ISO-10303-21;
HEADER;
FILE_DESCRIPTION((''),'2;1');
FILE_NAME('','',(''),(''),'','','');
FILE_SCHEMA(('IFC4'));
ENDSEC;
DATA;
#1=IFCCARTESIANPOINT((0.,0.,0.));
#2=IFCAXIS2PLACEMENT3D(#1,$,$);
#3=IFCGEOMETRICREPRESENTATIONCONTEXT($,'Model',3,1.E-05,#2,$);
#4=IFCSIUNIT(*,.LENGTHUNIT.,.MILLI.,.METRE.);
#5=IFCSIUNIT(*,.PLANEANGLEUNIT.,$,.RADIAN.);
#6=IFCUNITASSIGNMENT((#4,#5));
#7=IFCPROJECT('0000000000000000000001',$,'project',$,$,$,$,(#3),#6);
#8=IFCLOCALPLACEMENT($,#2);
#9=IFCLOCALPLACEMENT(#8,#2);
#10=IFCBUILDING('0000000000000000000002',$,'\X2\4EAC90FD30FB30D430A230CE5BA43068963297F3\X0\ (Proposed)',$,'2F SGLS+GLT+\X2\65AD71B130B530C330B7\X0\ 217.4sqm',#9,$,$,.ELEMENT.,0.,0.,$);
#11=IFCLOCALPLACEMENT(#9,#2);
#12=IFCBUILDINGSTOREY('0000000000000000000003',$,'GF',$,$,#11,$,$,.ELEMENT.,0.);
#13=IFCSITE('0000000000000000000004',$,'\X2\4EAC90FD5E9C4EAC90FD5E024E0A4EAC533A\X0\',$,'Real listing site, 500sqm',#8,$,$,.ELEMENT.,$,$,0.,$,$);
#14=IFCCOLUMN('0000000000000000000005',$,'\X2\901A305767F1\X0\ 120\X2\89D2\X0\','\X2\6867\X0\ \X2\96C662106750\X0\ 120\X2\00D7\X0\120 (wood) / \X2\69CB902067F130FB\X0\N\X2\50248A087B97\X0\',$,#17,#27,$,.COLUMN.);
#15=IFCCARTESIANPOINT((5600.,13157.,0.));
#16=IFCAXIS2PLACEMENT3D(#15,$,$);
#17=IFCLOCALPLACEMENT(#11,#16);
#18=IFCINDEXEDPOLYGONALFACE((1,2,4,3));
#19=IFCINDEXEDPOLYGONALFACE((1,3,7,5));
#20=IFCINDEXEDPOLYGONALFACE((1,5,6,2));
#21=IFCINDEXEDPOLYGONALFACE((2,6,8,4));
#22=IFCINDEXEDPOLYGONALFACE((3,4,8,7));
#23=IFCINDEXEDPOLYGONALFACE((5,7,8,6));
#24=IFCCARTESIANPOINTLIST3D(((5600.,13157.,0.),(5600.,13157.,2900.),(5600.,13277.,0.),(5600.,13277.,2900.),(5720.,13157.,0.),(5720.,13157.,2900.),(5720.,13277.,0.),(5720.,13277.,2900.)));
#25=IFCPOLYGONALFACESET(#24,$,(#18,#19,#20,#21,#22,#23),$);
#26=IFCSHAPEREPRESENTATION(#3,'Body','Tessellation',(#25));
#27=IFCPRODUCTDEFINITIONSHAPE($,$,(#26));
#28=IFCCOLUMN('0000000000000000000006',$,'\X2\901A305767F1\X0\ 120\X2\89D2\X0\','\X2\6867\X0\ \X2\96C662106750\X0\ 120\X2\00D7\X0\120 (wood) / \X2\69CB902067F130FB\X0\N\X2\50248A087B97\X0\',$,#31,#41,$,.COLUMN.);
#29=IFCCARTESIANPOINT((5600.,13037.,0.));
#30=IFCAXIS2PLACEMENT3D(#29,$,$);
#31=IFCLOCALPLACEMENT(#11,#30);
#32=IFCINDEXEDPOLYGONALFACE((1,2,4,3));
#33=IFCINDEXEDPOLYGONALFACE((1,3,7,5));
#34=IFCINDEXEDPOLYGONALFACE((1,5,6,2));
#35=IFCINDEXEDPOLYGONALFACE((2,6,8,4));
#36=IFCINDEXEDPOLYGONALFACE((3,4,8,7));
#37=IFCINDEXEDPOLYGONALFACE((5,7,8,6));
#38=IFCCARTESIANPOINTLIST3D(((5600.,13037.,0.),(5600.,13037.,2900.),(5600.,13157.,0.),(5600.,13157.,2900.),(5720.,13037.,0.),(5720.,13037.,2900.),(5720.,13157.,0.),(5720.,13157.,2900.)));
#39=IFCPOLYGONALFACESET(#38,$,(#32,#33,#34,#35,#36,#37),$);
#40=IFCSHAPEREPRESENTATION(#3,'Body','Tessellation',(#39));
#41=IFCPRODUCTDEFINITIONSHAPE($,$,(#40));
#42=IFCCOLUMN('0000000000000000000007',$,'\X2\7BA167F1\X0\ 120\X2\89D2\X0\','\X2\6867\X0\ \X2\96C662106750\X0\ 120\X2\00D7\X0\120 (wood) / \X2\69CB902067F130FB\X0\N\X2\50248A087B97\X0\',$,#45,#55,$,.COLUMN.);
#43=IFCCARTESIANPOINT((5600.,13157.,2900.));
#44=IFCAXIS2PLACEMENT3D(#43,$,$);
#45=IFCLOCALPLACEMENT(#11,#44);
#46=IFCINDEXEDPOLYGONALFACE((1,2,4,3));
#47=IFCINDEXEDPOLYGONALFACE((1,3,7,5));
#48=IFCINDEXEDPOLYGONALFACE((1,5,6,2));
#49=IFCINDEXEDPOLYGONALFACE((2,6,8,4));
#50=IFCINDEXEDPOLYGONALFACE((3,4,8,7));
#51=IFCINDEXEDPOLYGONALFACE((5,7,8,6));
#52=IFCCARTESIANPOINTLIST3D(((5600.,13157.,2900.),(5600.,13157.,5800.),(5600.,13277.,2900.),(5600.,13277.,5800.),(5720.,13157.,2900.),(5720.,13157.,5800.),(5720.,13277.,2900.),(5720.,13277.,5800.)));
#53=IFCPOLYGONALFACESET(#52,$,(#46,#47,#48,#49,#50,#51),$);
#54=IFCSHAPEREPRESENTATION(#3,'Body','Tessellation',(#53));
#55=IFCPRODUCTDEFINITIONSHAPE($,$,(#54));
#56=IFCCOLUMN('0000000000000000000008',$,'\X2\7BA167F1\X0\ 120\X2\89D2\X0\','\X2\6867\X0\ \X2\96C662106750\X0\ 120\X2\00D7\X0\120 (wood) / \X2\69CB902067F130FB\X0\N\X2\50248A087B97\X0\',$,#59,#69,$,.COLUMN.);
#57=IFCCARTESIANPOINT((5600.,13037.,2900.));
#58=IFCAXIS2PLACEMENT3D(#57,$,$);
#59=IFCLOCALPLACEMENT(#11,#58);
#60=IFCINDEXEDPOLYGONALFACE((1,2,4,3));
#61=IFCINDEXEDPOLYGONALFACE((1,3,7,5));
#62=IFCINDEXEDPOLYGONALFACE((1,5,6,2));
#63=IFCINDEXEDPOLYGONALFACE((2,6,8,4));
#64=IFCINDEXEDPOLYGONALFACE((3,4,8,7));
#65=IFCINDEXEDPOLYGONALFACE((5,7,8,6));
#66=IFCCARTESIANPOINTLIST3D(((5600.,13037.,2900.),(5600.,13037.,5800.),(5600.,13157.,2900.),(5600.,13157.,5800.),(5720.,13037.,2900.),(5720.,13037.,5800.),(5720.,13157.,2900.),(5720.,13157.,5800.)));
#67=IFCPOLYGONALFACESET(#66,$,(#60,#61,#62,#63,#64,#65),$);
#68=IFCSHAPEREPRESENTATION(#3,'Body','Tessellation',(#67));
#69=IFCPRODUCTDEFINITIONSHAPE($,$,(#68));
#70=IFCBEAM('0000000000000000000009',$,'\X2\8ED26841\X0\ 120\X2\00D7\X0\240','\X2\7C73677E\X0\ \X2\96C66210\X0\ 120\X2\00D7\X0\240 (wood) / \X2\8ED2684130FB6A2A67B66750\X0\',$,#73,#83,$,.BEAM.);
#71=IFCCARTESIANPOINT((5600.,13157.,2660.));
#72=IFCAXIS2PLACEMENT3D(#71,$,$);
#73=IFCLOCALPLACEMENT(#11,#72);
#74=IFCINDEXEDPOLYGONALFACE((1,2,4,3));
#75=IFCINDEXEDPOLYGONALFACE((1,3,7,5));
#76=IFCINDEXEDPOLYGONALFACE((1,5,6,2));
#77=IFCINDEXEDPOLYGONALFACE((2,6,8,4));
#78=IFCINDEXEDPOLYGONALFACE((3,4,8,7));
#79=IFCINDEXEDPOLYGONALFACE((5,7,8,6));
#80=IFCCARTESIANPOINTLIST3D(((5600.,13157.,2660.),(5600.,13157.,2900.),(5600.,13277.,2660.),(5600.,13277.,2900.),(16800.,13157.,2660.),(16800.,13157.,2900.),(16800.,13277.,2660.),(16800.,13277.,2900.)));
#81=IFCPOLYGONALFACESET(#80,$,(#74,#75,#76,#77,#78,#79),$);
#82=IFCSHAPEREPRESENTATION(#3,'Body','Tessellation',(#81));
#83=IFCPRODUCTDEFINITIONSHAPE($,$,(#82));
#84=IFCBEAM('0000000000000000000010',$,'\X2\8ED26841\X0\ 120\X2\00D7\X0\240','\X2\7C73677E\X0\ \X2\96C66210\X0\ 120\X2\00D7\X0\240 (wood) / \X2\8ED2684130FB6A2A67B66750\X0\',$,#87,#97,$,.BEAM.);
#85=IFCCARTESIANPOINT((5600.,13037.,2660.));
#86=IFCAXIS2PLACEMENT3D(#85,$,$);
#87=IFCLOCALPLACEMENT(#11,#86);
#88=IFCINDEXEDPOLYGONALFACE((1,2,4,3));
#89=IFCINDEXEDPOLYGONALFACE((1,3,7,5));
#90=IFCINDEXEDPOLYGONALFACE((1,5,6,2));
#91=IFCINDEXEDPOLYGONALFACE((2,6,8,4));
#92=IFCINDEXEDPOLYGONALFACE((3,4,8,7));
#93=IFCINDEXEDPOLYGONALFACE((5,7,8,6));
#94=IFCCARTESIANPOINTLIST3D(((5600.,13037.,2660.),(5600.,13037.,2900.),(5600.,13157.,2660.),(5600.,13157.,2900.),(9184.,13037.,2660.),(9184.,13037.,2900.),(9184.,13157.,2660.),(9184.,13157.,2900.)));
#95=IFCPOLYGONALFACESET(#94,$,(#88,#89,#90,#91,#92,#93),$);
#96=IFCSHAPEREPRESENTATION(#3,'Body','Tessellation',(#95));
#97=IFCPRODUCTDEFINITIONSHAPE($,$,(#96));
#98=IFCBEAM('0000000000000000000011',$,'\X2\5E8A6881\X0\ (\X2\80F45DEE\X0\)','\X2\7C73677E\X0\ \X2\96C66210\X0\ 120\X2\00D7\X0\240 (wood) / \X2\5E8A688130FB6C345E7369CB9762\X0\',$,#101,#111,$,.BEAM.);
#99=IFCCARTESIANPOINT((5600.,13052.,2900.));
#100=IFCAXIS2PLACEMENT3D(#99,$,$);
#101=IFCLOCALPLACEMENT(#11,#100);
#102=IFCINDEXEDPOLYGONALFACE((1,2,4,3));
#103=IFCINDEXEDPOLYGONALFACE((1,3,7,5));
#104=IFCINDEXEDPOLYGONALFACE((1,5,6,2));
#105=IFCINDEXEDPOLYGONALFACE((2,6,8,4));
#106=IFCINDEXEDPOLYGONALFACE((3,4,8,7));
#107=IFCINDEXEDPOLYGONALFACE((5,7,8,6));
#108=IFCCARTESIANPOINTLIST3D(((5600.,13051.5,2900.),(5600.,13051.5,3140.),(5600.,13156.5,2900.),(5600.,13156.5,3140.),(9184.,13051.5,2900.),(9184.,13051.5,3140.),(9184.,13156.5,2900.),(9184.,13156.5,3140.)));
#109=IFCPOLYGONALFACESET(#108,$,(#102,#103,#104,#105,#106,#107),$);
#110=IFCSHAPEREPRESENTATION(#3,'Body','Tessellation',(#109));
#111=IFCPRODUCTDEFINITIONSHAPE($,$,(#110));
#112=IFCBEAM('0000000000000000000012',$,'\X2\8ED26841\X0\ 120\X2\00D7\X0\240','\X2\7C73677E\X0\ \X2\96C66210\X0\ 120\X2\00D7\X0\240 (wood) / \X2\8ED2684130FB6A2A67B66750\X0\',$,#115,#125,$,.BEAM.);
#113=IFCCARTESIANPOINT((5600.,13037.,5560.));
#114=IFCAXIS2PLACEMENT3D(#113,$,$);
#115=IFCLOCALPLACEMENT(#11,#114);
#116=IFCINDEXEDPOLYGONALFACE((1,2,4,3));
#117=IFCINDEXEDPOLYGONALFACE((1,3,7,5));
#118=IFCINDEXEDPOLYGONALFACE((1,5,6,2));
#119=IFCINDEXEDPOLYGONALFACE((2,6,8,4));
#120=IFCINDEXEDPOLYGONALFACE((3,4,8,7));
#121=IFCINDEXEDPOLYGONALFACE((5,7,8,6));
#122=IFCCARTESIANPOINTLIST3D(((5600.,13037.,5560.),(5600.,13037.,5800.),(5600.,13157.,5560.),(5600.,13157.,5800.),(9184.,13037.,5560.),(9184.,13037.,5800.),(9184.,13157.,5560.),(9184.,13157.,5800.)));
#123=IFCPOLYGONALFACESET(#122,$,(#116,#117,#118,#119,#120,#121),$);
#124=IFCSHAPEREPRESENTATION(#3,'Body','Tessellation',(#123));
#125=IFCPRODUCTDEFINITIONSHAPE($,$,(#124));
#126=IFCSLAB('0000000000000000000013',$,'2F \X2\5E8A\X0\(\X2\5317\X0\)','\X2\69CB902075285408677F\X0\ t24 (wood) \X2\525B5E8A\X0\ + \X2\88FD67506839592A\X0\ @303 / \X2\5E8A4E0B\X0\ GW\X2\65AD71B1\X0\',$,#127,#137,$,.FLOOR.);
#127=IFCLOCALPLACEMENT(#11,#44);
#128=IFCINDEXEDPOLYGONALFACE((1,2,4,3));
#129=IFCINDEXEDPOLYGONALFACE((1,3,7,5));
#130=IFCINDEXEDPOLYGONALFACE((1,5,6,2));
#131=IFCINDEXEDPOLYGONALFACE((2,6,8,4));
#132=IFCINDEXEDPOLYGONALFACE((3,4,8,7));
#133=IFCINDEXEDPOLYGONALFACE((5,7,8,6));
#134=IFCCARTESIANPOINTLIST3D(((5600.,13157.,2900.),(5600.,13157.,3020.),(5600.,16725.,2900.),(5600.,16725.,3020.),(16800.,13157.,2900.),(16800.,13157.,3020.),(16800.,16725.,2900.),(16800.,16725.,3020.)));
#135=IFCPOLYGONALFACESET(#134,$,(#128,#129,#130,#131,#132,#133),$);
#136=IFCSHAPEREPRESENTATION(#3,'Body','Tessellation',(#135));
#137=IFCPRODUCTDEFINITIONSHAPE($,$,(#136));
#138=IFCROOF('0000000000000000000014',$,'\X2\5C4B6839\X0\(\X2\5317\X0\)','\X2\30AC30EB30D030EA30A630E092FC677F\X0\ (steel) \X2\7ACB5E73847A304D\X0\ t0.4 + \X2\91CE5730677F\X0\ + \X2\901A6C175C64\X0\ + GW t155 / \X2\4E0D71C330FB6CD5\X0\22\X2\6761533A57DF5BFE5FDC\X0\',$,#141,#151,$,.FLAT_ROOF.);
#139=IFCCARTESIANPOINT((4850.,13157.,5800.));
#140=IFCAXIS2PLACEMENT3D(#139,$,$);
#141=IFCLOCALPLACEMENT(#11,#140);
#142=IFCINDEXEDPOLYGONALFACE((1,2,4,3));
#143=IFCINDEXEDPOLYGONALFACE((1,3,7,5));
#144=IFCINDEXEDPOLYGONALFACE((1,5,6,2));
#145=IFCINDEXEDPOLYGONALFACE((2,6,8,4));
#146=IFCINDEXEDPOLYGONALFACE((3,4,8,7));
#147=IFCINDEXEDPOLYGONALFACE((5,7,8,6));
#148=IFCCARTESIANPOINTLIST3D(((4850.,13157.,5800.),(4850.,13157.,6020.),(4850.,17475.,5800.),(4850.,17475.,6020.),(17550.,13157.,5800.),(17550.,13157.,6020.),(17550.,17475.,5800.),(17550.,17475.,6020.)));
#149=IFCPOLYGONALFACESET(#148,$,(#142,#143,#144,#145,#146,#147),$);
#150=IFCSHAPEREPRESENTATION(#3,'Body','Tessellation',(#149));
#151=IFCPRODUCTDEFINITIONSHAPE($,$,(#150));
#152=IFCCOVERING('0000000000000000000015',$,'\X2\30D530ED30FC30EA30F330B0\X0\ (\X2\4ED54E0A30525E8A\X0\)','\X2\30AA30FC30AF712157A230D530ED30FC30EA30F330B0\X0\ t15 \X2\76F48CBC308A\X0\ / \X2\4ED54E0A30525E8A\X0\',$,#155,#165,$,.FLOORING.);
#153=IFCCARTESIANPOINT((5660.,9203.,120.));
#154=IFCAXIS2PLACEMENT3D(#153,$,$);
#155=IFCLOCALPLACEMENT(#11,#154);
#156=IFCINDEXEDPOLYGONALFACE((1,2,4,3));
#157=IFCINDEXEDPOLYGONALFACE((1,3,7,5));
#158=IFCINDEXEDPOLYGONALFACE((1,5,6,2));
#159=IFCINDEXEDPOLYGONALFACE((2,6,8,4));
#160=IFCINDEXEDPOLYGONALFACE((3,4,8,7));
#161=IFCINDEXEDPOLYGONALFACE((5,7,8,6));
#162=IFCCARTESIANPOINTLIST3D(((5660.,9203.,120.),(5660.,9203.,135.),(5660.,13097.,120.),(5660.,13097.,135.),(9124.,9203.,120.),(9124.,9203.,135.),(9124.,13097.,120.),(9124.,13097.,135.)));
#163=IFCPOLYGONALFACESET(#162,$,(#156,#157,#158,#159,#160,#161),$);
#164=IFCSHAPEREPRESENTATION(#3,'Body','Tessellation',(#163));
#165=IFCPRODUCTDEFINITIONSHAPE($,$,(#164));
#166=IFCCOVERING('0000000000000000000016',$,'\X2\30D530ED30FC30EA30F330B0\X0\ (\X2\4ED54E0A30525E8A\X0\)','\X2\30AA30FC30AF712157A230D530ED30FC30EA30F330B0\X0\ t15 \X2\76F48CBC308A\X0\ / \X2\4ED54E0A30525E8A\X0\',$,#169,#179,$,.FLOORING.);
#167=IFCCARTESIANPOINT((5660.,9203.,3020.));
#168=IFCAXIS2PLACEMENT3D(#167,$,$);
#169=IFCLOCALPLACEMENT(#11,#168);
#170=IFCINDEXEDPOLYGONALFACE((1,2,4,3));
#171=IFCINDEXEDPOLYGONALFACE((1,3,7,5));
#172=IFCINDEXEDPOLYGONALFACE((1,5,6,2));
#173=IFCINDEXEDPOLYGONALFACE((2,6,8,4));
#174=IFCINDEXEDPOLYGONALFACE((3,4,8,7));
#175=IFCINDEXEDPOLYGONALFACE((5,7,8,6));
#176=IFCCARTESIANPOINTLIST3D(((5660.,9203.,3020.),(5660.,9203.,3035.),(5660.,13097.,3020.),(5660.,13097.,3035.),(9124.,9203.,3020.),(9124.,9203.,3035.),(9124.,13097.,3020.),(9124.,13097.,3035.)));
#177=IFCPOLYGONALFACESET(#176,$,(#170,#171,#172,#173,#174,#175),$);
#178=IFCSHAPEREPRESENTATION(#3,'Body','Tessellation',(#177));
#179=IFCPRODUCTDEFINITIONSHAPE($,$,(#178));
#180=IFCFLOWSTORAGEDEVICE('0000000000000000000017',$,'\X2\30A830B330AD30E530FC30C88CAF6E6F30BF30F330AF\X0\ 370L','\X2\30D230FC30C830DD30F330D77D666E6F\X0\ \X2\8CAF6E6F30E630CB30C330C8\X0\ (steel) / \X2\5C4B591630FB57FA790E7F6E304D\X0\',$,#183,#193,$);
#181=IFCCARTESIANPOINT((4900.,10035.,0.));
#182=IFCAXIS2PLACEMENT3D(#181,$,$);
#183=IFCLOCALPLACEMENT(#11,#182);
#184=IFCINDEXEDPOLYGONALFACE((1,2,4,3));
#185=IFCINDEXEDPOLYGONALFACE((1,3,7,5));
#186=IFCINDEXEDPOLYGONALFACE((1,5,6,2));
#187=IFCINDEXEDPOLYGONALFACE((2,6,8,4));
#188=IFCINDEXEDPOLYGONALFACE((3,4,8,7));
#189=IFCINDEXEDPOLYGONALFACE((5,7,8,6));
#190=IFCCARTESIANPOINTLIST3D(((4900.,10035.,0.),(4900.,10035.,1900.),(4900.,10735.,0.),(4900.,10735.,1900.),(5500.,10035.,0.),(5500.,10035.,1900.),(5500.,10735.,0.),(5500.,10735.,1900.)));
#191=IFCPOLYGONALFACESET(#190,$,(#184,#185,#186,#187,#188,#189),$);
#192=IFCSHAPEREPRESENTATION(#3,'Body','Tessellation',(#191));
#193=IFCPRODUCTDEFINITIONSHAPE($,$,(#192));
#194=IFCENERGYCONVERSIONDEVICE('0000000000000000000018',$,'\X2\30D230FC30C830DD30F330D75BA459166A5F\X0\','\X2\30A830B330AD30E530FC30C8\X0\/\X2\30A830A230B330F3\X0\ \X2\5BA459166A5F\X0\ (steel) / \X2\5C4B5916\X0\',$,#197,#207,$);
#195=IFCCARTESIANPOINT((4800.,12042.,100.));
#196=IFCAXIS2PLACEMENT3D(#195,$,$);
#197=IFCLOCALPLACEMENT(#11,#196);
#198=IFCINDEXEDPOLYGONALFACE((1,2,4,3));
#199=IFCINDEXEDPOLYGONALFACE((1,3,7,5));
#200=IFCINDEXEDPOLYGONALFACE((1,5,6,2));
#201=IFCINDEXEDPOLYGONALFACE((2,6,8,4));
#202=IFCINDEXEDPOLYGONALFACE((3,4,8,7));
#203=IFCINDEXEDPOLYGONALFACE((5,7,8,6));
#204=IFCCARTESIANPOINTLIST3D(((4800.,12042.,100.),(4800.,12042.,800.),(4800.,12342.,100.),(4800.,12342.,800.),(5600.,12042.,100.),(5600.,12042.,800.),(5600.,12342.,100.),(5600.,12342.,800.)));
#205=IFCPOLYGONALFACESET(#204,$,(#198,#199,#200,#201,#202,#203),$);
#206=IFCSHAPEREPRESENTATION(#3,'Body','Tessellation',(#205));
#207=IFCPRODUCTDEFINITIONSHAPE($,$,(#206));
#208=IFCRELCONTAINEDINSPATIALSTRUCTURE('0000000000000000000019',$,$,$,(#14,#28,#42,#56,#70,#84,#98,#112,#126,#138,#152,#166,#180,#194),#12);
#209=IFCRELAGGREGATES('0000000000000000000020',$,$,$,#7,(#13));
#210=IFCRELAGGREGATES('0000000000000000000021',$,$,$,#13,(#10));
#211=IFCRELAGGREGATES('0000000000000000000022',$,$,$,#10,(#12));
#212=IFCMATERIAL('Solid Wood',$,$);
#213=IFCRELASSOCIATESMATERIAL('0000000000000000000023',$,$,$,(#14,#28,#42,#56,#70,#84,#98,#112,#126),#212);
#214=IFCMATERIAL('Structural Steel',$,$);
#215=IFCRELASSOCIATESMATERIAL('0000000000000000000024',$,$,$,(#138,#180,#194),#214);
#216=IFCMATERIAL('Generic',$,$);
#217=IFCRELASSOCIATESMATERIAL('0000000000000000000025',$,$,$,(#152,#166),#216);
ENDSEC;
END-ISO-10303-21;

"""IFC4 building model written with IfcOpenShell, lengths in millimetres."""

from ifc_helpers import new_model, si_unit, frame, frame_2d, origin, place, context, project, spatial, rectangle, extrude, material, element, save


model = new_model("IFC4")

# Units and contexts
model_context = context("Model", 3, precision=1e-05, world=origin())
ifc_project = project(units=[si_unit("LENGTHUNIT", "METRE", prefix="MILLI"), si_unit("PLANEANGLEUNIT", "RADIAN")], contexts=[model_context])

# Site, building, storey
site_placement = place(None, origin())
site = spatial("IfcSite", under=ifc_project, at=site_placement, Name="京都府京都市上京区", ObjectType="Real listing site, 500sqm", CompositionType="ELEMENT", RefElevation=0.0)
building_placement = place(site_placement, origin())
building = spatial("IfcBuilding", under=site, at=building_placement, Name="京都・ピアノ室と防音 (Proposed)", ObjectType="2F SGLS+GLT+断熱サッシ 217.4sqm", CompositionType="ELEMENT", ElevationOfRefHeight=0.0, ElevationOfTerrain=0.0)
storey_placement = place(building_placement, origin())
storey = spatial("IfcBuildingStorey", under=building, at=storey_placement, Name="GF", CompositionType="ELEMENT", Elevation=0.0)

# Columns
ifc_material_1 = material(Name="Solid Wood")
column_1_placement = place(storey_placement, frame((5600.0, 13157.0, 0.0)))
element("IfcColumn", 1, at=column_1_placement, inside=storey, material=ifc_material_1, Name="通し柱 120角", Description="桧 集成材 120×120 (wood) / 構造柱・N値計算", PredefinedType="COLUMN", context=model_context, shape_type="SweptSolid", body=[
    extrude(rectangle(XDim=120.0, YDim=120.0, at=frame_2d((60.0, 60.0))), frame((5600.0, 13157.0, 0.0)), (0.0, 0.0, 1.0), 2900.0),
])
column_2_placement = place(storey_placement, frame((5600.0, 13037.0, 0.0)))
element("IfcColumn", 2, at=column_2_placement, inside=storey, material=ifc_material_1, Name="通し柱 120角", Description="桧 集成材 120×120 (wood) / 構造柱・N値計算", PredefinedType="COLUMN", context=model_context, shape_type="SweptSolid", body=[
    extrude(rectangle(XDim=120.0, YDim=120.0, at=frame_2d((60.0, 60.0))), frame((5600.0, 13037.0, 0.0)), (0.0, 0.0, 1.0), 2900.0),
])
column_3_placement = place(storey_placement, frame((5600.0, 13157.0, 2900.0)))
element("IfcColumn", 3, at=column_3_placement, inside=storey, material=ifc_material_1, Name="管柱 120角", Description="桧 集成材 120×120 (wood) / 構造柱・N値計算", PredefinedType="COLUMN", context=model_context, shape_type="SweptSolid", body=[
    extrude(rectangle(XDim=120.0, YDim=120.0, at=frame_2d((60.0, 60.0))), frame((5600.0, 13157.0, 2900.0)), (0.0, 0.0, 1.0), 2900.0),
])
column_4_placement = place(storey_placement, frame((5600.0, 13037.0, 2900.0)))
element("IfcColumn", 4, at=column_4_placement, inside=storey, material=ifc_material_1, Name="管柱 120角", Description="桧 集成材 120×120 (wood) / 構造柱・N値計算", PredefinedType="COLUMN", context=model_context, shape_type="SweptSolid", body=[
    extrude(rectangle(XDim=120.0, YDim=120.0, at=frame_2d((60.0, 60.0))), frame((5600.0, 13037.0, 2900.0)), (0.0, 0.0, 1.0), 2900.0),
])

# Beams
beam_1_placement = place(storey_placement, frame((5600.0, 13157.0, 2660.0)))
element("IfcBeam", 5, at=beam_1_placement, inside=storey, material=ifc_material_1, Name="軒桁 120×240", Description="米松 集成 120×240 (wood) / 軒桁・横架材", PredefinedType="BEAM", context=model_context, shape_type="SweptSolid", body=[
    extrude(rectangle(XDim=11200.0, YDim=120.0, at=frame_2d((5600.0, 60.0))), frame((5600.0, 13157.0, 2660.0)), (0.0, 0.0, 1.0), 240.0),
])
beam_2_placement = place(storey_placement, frame((5600.0, 13037.0, 2660.0)))
element("IfcBeam", 6, at=beam_2_placement, inside=storey, material=ifc_material_1, Name="軒桁 120×240", Description="米松 集成 120×240 (wood) / 軒桁・横架材", PredefinedType="BEAM", context=model_context, shape_type="SweptSolid", body=[
    extrude(rectangle(XDim=3584.0, YDim=120.0, at=frame_2d((1792.0, 60.0))), frame((5600.0, 13037.0, 2660.0)), (0.0, 0.0, 1.0), 240.0),
])
beam_3_placement = place(storey_placement, frame((5600.0, 13052.0, 2900.0)))
element("IfcBeam", 7, at=beam_3_placement, inside=storey, material=ifc_material_1, Name="床梁 (胴差)", Description="米松 集成 120×240 (wood) / 床梁・水平構面", PredefinedType="BEAM", context=model_context, shape_type="SweptSolid", body=[
    extrude(rectangle(XDim=3584.0, YDim=105.0, at=frame_2d((1792.0, 52.0))), frame((5600.0, 13052.0, 2900.0)), (0.0, 0.0, 1.0), 240.0),
])
beam_4_placement = place(storey_placement, frame((5600.0, 13037.0, 5560.0)))
element("IfcBeam", 8, at=beam_4_placement, inside=storey, material=ifc_material_1, Name="軒桁 120×240", Description="米松 集成 120×240 (wood) / 軒桁・横架材", PredefinedType="BEAM", context=model_context, shape_type="SweptSolid", body=[
    extrude(rectangle(XDim=3584.0, YDim=120.0, at=frame_2d((1792.0, 60.0))), frame((5600.0, 13037.0, 5560.0)), (0.0, 0.0, 1.0), 240.0),
])

# Slab
slab_1_placement = place(storey_placement, frame((5600.0, 13157.0, 2900.0)))
element("IfcSlab", 9, at=slab_1_placement, inside=storey, material=ifc_material_1, Name="2F 床(北)", Description="構造用合板 t24 (wood) 剛床 + 製材根太 @303 / 床下 GW断熱", PredefinedType="FLOOR", context=model_context, shape_type="SweptSolid", body=[
    extrude(rectangle(XDim=11200.0, YDim=3568.0, at=frame_2d((5600.0, 1784.0))), frame((5600.0, 13157.0, 2900.0)), (0.0, 0.0, 1.0), 120.0),
])

# Roof
ifc_material_2 = material(Name="Structural Steel")
for number, where, name in (
    (10, (4850.0, 13157.0, 5800.0), "屋根(北)"),
):
    element("IfcRoof", number, at=place(storey_placement, frame(where)), inside=storey, material=ifc_material_2, Name=name, Description="ガルバリウム鋼板 (steel) 立平葺き t0.4 + 野地板 + 通気層 + GW t155 / 不燃・法22条区域対応", PredefinedType="FLAT_ROOF", context=model_context, shape_type="SweptSolid", body=[
        extrude(rectangle(XDim=12700.0, YDim=4318.0, at=frame_2d((6350.0, 2159.0))), frame((4850.0, 13157.0, 5800.0)), (0.0, 0.0, 1.0), 220.0),
    ])

# Coverings
ifc_material_3 = material(Name="Generic")
covering_1_placement = place(storey_placement, frame((5660.0, 9203.0, 120.0)))
element("IfcCovering", 11, at=covering_1_placement, inside=storey, material=ifc_material_3, Name="フローリング (仕上げ床)", Description="オーク無垢フローリング t15 直貼り / 仕上げ床", PredefinedType="FLOORING", context=model_context, shape_type="SweptSolid", body=[
    extrude(rectangle(XDim=3464.0, YDim=3894.0, at=frame_2d((1732.0, 1947.0))), frame((5660.0, 9203.0, 120.0)), (0.0, 0.0, 1.0), 15.0),
])
covering_2_placement = place(storey_placement, frame((5660.0, 9203.0, 3020.0)))
element("IfcCovering", 12, at=covering_2_placement, inside=storey, material=ifc_material_3, Name="フローリング (仕上げ床)", Description="オーク無垢フローリング t15 直貼り / 仕上げ床", PredefinedType="FLOORING", context=model_context, shape_type="SweptSolid", body=[
    extrude(rectangle(XDim=3464.0, YDim=3894.0, at=frame_2d((1732.0, 1947.0))), frame((5660.0, 9203.0, 3020.0)), (0.0, 0.0, 1.0), 15.0),
])

# Flow storage device
flow_storage_device_placement = place(storey_placement, frame((4900.0, 10035.0, 0.0)))
element("IfcFlowStorageDevice", 13, at=flow_storage_device_placement, inside=storey, material=ifc_material_2, Name="エコキュート貯湯タンク 370L", Description="ヒートポンプ給湯 貯湯ユニット (steel) / 屋外・基礎置き", context=model_context, shape_type="SweptSolid", body=[
    extrude(rectangle(XDim=600.0, YDim=700.0, at=frame_2d((300.0, 350.0))), frame((4900.0, 10035.0, 0.0)), (0.0, 0.0, 1.0), 1900.0),
])

# Energy conversion device
energy_conversion_device_placement = place(storey_placement, frame((4800.0, 12042.0, 100.0)))
element("IfcEnergyConversionDevice", 14, at=energy_conversion_device_placement, inside=storey, material=ifc_material_2, Name="ヒートポンプ室外機", Description="エコキュート/エアコン 室外機 (steel) / 屋外", context=model_context, shape_type="SweptSolid", body=[
    extrude(rectangle(XDim=800.0, YDim=300.0, at=frame_2d((400.0, 150.0))), frame((4800.0, 12042.0, 100.0)), (0.0, 0.0, 1.0), 700.0),
])

save(model, "model.ifc")
